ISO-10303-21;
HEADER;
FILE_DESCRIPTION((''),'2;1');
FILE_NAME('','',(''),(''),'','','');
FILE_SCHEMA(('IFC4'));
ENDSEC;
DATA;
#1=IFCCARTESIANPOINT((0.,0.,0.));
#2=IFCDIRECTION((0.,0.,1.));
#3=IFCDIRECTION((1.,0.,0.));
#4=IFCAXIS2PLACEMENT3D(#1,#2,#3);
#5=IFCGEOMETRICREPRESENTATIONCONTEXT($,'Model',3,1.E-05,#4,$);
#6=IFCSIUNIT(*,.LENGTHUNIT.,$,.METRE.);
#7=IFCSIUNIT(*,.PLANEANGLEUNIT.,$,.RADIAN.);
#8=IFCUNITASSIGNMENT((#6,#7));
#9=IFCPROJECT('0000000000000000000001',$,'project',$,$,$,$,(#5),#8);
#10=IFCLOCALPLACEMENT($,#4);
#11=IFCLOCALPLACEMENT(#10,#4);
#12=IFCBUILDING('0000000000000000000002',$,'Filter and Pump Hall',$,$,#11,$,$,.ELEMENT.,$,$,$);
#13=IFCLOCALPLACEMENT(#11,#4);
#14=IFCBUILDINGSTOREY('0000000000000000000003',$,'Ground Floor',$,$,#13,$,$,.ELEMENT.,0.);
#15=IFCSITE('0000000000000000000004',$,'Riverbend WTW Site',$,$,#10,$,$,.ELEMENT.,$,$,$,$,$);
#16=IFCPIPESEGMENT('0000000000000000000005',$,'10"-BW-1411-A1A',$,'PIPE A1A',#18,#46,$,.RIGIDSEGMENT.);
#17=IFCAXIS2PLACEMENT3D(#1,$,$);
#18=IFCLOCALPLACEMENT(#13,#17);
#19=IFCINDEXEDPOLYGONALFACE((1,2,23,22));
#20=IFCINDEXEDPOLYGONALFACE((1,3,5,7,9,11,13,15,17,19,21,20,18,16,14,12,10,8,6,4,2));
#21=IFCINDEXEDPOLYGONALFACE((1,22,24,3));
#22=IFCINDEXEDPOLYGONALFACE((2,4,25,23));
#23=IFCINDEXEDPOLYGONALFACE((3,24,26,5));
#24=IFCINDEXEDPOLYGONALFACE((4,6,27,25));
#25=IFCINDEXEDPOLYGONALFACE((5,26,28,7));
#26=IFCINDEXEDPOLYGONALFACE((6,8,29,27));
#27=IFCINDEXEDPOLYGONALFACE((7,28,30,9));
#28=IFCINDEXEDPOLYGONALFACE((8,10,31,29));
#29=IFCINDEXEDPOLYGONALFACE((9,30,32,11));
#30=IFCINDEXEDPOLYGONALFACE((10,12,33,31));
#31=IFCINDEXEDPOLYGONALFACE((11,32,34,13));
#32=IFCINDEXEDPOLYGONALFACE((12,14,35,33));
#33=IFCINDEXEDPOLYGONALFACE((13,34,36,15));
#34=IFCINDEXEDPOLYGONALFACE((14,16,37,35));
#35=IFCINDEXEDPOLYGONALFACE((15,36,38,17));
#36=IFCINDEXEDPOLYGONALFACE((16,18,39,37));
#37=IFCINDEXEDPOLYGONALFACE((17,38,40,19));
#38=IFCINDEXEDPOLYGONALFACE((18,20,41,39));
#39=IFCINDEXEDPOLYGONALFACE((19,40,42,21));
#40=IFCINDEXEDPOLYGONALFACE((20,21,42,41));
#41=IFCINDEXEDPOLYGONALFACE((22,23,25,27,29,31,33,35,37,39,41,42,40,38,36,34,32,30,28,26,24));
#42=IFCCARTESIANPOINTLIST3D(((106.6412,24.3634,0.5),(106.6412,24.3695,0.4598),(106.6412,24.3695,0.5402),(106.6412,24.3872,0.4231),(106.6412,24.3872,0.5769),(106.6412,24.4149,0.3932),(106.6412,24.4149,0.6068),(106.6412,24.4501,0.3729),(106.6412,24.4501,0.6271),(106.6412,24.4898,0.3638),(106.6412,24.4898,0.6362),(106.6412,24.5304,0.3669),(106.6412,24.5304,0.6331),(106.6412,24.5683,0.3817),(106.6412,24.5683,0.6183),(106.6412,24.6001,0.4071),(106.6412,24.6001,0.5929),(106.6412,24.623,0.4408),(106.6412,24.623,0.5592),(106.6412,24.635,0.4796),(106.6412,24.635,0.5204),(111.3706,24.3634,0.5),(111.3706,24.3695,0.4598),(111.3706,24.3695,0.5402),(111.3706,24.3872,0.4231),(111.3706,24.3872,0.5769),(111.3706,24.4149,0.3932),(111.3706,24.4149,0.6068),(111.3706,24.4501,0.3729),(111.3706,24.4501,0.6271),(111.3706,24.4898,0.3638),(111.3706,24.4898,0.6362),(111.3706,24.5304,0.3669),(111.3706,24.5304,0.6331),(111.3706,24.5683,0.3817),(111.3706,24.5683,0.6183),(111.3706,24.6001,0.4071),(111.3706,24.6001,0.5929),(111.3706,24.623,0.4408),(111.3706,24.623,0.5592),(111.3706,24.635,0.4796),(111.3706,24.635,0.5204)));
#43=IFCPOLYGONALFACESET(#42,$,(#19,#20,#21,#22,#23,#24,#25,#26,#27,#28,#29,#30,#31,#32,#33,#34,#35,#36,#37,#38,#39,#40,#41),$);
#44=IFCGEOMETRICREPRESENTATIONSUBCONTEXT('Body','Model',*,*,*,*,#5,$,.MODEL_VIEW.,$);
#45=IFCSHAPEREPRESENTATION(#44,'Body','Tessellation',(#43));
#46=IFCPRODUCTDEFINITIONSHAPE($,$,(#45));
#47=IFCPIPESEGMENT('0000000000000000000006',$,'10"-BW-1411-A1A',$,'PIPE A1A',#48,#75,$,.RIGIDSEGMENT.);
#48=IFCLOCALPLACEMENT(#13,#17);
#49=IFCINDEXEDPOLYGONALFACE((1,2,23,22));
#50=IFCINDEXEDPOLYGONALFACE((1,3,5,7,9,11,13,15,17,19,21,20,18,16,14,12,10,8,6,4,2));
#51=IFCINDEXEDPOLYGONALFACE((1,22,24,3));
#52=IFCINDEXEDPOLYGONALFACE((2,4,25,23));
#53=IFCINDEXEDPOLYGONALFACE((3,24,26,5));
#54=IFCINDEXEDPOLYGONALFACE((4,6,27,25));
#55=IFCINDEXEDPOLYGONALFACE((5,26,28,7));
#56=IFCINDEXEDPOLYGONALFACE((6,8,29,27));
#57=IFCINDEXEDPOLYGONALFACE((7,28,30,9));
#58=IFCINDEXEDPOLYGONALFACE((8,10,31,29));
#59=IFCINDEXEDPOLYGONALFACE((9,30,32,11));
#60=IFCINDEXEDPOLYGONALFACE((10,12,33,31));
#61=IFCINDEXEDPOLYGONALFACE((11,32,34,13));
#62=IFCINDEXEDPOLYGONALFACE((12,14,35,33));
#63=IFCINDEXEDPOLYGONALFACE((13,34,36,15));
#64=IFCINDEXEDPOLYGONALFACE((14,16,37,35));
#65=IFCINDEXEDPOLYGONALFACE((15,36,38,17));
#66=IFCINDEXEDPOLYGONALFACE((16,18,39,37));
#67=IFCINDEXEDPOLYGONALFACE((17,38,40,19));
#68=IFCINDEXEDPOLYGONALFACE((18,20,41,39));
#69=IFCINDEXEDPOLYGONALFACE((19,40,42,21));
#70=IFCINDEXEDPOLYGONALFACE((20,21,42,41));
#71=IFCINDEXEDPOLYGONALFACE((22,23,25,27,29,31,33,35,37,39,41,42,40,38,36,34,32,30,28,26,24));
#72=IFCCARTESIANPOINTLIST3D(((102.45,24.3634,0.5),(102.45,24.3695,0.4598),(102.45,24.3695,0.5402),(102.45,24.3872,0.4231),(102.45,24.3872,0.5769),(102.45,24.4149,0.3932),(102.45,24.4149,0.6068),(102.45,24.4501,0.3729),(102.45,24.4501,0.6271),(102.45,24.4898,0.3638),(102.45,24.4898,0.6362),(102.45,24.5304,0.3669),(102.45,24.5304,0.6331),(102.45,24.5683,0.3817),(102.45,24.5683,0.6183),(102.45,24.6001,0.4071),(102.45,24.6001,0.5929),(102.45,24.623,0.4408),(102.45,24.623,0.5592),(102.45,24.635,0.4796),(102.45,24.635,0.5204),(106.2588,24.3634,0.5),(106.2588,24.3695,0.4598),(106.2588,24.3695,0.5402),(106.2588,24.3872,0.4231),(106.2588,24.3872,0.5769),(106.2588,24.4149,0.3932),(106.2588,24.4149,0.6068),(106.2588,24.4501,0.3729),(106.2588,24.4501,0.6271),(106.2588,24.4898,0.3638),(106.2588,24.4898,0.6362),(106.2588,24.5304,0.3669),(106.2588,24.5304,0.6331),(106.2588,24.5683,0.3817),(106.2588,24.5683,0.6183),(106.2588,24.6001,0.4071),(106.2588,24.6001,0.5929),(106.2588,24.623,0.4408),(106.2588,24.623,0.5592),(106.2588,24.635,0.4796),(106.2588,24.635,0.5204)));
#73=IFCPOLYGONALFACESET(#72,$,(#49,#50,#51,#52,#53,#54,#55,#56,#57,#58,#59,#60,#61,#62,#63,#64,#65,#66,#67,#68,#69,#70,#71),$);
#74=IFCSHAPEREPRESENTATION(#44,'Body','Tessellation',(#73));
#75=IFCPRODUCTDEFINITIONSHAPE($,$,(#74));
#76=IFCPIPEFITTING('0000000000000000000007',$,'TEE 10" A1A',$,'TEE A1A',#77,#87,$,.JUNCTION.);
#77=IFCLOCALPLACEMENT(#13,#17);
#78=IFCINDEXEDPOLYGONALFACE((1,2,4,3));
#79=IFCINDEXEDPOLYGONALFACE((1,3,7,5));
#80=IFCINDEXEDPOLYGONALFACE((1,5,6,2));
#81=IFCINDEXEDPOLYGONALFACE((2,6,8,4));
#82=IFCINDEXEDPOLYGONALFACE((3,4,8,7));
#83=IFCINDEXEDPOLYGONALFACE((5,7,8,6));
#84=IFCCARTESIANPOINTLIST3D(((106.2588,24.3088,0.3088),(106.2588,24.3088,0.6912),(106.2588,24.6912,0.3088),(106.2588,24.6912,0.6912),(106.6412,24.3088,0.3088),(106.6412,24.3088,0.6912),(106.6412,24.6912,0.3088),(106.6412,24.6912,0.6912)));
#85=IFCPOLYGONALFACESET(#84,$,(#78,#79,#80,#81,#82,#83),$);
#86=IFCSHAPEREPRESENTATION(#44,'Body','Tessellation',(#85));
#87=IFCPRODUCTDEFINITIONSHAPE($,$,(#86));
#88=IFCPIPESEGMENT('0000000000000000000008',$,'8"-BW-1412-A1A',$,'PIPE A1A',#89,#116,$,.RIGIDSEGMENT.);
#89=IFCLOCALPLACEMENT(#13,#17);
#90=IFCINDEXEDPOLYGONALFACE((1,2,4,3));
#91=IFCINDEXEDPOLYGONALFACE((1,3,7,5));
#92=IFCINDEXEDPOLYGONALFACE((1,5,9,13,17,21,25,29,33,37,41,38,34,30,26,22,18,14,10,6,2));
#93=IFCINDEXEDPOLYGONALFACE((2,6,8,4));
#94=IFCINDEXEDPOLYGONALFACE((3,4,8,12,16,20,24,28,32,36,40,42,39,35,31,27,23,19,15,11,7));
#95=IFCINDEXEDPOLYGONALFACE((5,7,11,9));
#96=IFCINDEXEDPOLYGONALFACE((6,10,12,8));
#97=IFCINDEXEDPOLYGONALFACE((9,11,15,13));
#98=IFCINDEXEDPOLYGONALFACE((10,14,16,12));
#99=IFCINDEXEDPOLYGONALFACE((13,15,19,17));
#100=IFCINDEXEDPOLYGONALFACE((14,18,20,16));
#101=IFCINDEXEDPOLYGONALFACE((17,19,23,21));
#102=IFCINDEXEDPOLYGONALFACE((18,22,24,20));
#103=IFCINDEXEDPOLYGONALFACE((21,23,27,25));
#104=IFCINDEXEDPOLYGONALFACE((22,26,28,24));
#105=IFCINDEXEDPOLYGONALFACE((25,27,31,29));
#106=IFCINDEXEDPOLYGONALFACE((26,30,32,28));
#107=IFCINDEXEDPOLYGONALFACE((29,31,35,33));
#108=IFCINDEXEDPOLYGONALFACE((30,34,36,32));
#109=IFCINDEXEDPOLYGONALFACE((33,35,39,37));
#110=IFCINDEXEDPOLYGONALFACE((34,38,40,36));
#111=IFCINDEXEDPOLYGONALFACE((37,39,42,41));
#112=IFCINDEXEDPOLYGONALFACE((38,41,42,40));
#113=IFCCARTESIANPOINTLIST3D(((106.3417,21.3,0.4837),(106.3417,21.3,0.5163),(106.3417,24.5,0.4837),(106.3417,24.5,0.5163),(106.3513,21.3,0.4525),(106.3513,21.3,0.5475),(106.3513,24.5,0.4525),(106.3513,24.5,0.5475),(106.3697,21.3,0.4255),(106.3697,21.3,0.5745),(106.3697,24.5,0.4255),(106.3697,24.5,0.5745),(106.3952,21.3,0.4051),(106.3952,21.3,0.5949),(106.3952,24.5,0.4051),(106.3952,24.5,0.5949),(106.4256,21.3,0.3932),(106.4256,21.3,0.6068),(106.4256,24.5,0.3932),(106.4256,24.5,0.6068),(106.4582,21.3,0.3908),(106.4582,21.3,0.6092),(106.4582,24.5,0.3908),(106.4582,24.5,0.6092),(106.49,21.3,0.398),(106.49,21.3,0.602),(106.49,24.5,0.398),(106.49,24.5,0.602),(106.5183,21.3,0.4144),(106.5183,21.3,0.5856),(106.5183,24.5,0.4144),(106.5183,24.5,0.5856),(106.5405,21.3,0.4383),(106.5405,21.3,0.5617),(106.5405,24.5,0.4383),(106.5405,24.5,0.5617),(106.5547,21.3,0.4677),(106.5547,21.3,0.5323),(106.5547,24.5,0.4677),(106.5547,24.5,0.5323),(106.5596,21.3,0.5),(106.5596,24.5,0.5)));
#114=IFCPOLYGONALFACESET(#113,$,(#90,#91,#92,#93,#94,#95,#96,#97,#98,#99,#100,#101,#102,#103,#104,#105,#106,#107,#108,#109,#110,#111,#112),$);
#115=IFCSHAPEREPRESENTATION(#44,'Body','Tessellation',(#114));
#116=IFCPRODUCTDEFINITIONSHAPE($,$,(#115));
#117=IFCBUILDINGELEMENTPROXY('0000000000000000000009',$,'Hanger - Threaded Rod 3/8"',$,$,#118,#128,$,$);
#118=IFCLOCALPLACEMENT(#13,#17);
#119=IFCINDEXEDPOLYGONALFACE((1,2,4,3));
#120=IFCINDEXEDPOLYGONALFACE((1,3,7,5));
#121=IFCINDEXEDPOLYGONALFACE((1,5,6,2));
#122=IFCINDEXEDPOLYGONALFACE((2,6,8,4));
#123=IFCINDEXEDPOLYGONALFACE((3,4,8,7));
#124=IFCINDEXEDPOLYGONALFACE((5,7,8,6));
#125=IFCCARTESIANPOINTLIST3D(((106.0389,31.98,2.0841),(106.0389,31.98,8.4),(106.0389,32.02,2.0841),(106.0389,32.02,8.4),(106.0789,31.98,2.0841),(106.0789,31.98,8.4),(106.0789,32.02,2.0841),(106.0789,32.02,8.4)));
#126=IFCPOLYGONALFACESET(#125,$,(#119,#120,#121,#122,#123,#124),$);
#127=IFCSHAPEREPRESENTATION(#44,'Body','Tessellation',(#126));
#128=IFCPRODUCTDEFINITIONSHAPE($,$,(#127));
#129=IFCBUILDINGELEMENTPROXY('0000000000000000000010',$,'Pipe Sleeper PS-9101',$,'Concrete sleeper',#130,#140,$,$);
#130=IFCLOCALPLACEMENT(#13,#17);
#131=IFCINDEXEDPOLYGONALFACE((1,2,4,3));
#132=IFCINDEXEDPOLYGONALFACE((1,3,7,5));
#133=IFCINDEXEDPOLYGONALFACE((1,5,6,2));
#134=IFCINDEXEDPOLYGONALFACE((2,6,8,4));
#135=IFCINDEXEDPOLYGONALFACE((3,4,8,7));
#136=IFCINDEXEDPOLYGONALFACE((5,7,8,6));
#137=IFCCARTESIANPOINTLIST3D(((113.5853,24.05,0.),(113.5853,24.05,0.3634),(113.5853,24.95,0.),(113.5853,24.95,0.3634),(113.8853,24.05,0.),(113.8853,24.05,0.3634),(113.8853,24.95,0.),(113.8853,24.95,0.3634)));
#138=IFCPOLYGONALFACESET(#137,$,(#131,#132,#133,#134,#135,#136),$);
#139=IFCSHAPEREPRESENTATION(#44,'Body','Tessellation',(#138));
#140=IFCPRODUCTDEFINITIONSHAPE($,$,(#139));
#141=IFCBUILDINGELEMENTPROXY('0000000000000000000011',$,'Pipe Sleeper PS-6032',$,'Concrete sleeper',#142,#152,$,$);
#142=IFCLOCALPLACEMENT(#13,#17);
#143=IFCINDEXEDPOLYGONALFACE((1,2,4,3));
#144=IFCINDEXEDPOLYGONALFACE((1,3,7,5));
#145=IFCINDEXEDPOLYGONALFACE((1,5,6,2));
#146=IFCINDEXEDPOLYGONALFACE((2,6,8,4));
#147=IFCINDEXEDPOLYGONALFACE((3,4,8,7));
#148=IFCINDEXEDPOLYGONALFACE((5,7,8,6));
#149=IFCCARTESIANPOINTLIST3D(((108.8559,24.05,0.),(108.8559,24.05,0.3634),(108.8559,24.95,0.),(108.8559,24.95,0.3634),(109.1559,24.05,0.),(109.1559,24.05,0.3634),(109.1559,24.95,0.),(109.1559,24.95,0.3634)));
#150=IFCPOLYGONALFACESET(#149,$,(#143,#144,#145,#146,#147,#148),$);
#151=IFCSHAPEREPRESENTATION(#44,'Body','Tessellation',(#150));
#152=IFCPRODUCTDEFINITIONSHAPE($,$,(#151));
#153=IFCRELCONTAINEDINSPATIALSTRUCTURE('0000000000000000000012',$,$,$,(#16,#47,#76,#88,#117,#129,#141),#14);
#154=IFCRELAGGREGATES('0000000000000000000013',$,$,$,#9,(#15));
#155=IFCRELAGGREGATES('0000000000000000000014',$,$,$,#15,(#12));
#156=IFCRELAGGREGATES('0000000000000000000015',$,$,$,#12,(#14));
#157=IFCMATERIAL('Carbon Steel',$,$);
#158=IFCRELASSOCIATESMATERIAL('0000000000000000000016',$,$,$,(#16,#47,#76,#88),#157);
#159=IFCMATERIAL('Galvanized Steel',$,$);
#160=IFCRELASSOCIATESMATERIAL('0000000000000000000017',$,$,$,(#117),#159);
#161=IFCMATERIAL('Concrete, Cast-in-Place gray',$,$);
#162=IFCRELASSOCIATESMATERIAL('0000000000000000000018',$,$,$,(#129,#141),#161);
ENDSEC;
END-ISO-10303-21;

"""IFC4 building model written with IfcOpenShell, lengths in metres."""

from ifc_helpers import new_model, si_unit, frame, origin_with_axes, origin_2d, place, context, subcontext, project, spatial, rectangle, circle, extrude, material, element, save


model = new_model("IFC4")

# Units and contexts
model_context = context("Model", 3, precision=1e-05, world=origin_with_axes())
body_context = subcontext(model_context, "Body", "Model", "MODEL_VIEW")
ifc_project = project(units=[si_unit("LENGTHUNIT", "METRE"), si_unit("PLANEANGLEUNIT", "RADIAN")], contexts=[model_context])

# Site, building, storey
site_placement = place(None, origin_with_axes())
site = spatial("IfcSite", under=ifc_project, at=site_placement, Name="Riverbend WTW Site", CompositionType="ELEMENT")
building_placement = place(site_placement, origin_with_axes())
building = spatial("IfcBuilding", under=site, at=building_placement, Name="Filter and Pump Hall", CompositionType="ELEMENT")
storey_placement = place(building_placement, origin_with_axes())
storey = spatial("IfcBuildingStorey", under=building, at=storey_placement, Name="Ground Floor", CompositionType="ELEMENT", Elevation=0.0)

# Shared definitions
ifc_material_1 = material(Name="Carbon Steel")

# Pipe segments
pipe_segment_1_placement = place(None, frame((111.3706, 24.5, 0.5), z_axis=(0.0, 0.0, 1.0), x_axis=(1.0, 0.0, 0.0)))
element("IfcPipeSegment", 1, at=pipe_segment_1_placement, inside=storey, material=ifc_material_1, Name="10\"-BW-1411-A1A", ObjectType="PIPE A1A", PredefinedType="RIGIDSEGMENT", context=body_context, shape_type="SweptSolid", body=[
    extrude(circle(Radius=0.1366, at=origin_2d()), frame((0.0, 0.0, 0.0), z_axis=(-1.0, 0.0, 0.0), x_axis=(0.0, -1.0, 0.0)), (0.0, 0.0, 1.0), 4.7294),
])
pipe_segment_2_placement = place(None, frame((106.2588, 24.5, 0.5), z_axis=(0.0, 0.0, 1.0), x_axis=(1.0, 0.0, 0.0)))
element("IfcPipeSegment", 2, at=pipe_segment_2_placement, inside=storey, material=ifc_material_1, Name="10\"-BW-1411-A1A", ObjectType="PIPE A1A", PredefinedType="RIGIDSEGMENT", context=body_context, shape_type="SweptSolid", body=[
    extrude(circle(Radius=0.1366, at=origin_2d()), frame((0.0, 0.0, 0.0), z_axis=(-1.0, 0.0, 0.0), x_axis=(0.0, -1.0, 0.0)), (0.0, 0.0, 1.0), 3.8088),
])

# Pipe fitting
pipe_fitting_1_placement = place(None, frame((106.45, 24.5, 0.5), z_axis=(0.0, 0.0, 1.0), x_axis=(1.0, 0.0, 0.0)))
element("IfcPipeFitting", 3, at=pipe_fitting_1_placement, inside=storey, material=ifc_material_1, Name="TEE 10\" A1A", ObjectType="TEE A1A", PredefinedType="JUNCTION", context=body_context, shape_type="SweptSolid", body=[
    extrude(rectangle(XDim=0.3823, YDim=0.3823, at=origin_2d()), frame((0.0, 0.0, -0.1912), z_axis=(0.0, 0.0, 1.0), x_axis=(1.0, 0.0, 0.0)), (0.0, 0.0, 1.0), 0.3823),
])

# Pipe segment
pipe_segment_3_placement = place(None, frame((106.45, 24.5, 0.5), z_axis=(0.0, 0.0, 1.0), x_axis=(1.0, 0.0, 0.0)))
element("IfcPipeSegment", 4, at=pipe_segment_3_placement, inside=storey, material=ifc_material_1, Name="8\"-BW-1412-A1A", ObjectType="PIPE A1A", PredefinedType="RIGIDSEGMENT", context=body_context, shape_type="SweptSolid", body=[
    extrude(circle(Radius=0.1095, at=origin_2d()), frame((0.0, 0.0, 0.0), z_axis=(0.0, -1.0, 0.0), x_axis=(1.0, 0.0, 0.0)), (0.0, 0.0, 1.0), 3.2),
])

# Building element proxies
ifc_material_2 = material(Name="Galvanized Steel")
proxy_placement = place(None, frame((106.0589, 32.0, 5.2421), z_axis=(0.0, 0.0, 1.0), x_axis=(1.0, 0.0, 0.0)))
element("IfcBuildingElementProxy", 5, at=proxy_placement, inside=storey, material=ifc_material_2, Name="Hanger - Threaded Rod 3/8\"", context=body_context, shape_type="SweptSolid", body=[
    extrude(rectangle(XDim=0.04, YDim=0.04, at=origin_2d()), frame((0.0, 0.0, -3.1579), z_axis=(0.0, 0.0, 1.0), x_axis=(1.0, 0.0, 0.0)), (0.0, 0.0, 1.0), 6.3159),
])
ifc_material_3 = material(Name="Concrete, Cast-in-Place gray")
for number, where, z_axis, x_axis, name in (
    (6, (113.7353, 24.5, 0.1817), (0.0, 0.0, 1.0), (1.0, 0.0, 0.0), "Pipe Sleeper PS-9101"),
    (7, (109.0059, 24.5, 0.1817), (0.0, 0.0, 1.0), (1.0, 0.0, 0.0), "Pipe Sleeper PS-6032"),
):
    element("IfcBuildingElementProxy", number, at=place(None, frame(where, z_axis=z_axis, x_axis=x_axis)), inside=storey, material=ifc_material_3, Name=name, ObjectType="Concrete sleeper", context=body_context, shape_type="SweptSolid", body=[
        extrude(rectangle(XDim=0.3, YDim=0.9, at=origin_2d()), frame((0.0, 0.0, -0.1817), z_axis=(0.0, 0.0, 1.0), x_axis=(1.0, 0.0, 0.0)), (0.0, 0.0, 1.0), 0.3634),
    ])

save(model, "model.ifc")
